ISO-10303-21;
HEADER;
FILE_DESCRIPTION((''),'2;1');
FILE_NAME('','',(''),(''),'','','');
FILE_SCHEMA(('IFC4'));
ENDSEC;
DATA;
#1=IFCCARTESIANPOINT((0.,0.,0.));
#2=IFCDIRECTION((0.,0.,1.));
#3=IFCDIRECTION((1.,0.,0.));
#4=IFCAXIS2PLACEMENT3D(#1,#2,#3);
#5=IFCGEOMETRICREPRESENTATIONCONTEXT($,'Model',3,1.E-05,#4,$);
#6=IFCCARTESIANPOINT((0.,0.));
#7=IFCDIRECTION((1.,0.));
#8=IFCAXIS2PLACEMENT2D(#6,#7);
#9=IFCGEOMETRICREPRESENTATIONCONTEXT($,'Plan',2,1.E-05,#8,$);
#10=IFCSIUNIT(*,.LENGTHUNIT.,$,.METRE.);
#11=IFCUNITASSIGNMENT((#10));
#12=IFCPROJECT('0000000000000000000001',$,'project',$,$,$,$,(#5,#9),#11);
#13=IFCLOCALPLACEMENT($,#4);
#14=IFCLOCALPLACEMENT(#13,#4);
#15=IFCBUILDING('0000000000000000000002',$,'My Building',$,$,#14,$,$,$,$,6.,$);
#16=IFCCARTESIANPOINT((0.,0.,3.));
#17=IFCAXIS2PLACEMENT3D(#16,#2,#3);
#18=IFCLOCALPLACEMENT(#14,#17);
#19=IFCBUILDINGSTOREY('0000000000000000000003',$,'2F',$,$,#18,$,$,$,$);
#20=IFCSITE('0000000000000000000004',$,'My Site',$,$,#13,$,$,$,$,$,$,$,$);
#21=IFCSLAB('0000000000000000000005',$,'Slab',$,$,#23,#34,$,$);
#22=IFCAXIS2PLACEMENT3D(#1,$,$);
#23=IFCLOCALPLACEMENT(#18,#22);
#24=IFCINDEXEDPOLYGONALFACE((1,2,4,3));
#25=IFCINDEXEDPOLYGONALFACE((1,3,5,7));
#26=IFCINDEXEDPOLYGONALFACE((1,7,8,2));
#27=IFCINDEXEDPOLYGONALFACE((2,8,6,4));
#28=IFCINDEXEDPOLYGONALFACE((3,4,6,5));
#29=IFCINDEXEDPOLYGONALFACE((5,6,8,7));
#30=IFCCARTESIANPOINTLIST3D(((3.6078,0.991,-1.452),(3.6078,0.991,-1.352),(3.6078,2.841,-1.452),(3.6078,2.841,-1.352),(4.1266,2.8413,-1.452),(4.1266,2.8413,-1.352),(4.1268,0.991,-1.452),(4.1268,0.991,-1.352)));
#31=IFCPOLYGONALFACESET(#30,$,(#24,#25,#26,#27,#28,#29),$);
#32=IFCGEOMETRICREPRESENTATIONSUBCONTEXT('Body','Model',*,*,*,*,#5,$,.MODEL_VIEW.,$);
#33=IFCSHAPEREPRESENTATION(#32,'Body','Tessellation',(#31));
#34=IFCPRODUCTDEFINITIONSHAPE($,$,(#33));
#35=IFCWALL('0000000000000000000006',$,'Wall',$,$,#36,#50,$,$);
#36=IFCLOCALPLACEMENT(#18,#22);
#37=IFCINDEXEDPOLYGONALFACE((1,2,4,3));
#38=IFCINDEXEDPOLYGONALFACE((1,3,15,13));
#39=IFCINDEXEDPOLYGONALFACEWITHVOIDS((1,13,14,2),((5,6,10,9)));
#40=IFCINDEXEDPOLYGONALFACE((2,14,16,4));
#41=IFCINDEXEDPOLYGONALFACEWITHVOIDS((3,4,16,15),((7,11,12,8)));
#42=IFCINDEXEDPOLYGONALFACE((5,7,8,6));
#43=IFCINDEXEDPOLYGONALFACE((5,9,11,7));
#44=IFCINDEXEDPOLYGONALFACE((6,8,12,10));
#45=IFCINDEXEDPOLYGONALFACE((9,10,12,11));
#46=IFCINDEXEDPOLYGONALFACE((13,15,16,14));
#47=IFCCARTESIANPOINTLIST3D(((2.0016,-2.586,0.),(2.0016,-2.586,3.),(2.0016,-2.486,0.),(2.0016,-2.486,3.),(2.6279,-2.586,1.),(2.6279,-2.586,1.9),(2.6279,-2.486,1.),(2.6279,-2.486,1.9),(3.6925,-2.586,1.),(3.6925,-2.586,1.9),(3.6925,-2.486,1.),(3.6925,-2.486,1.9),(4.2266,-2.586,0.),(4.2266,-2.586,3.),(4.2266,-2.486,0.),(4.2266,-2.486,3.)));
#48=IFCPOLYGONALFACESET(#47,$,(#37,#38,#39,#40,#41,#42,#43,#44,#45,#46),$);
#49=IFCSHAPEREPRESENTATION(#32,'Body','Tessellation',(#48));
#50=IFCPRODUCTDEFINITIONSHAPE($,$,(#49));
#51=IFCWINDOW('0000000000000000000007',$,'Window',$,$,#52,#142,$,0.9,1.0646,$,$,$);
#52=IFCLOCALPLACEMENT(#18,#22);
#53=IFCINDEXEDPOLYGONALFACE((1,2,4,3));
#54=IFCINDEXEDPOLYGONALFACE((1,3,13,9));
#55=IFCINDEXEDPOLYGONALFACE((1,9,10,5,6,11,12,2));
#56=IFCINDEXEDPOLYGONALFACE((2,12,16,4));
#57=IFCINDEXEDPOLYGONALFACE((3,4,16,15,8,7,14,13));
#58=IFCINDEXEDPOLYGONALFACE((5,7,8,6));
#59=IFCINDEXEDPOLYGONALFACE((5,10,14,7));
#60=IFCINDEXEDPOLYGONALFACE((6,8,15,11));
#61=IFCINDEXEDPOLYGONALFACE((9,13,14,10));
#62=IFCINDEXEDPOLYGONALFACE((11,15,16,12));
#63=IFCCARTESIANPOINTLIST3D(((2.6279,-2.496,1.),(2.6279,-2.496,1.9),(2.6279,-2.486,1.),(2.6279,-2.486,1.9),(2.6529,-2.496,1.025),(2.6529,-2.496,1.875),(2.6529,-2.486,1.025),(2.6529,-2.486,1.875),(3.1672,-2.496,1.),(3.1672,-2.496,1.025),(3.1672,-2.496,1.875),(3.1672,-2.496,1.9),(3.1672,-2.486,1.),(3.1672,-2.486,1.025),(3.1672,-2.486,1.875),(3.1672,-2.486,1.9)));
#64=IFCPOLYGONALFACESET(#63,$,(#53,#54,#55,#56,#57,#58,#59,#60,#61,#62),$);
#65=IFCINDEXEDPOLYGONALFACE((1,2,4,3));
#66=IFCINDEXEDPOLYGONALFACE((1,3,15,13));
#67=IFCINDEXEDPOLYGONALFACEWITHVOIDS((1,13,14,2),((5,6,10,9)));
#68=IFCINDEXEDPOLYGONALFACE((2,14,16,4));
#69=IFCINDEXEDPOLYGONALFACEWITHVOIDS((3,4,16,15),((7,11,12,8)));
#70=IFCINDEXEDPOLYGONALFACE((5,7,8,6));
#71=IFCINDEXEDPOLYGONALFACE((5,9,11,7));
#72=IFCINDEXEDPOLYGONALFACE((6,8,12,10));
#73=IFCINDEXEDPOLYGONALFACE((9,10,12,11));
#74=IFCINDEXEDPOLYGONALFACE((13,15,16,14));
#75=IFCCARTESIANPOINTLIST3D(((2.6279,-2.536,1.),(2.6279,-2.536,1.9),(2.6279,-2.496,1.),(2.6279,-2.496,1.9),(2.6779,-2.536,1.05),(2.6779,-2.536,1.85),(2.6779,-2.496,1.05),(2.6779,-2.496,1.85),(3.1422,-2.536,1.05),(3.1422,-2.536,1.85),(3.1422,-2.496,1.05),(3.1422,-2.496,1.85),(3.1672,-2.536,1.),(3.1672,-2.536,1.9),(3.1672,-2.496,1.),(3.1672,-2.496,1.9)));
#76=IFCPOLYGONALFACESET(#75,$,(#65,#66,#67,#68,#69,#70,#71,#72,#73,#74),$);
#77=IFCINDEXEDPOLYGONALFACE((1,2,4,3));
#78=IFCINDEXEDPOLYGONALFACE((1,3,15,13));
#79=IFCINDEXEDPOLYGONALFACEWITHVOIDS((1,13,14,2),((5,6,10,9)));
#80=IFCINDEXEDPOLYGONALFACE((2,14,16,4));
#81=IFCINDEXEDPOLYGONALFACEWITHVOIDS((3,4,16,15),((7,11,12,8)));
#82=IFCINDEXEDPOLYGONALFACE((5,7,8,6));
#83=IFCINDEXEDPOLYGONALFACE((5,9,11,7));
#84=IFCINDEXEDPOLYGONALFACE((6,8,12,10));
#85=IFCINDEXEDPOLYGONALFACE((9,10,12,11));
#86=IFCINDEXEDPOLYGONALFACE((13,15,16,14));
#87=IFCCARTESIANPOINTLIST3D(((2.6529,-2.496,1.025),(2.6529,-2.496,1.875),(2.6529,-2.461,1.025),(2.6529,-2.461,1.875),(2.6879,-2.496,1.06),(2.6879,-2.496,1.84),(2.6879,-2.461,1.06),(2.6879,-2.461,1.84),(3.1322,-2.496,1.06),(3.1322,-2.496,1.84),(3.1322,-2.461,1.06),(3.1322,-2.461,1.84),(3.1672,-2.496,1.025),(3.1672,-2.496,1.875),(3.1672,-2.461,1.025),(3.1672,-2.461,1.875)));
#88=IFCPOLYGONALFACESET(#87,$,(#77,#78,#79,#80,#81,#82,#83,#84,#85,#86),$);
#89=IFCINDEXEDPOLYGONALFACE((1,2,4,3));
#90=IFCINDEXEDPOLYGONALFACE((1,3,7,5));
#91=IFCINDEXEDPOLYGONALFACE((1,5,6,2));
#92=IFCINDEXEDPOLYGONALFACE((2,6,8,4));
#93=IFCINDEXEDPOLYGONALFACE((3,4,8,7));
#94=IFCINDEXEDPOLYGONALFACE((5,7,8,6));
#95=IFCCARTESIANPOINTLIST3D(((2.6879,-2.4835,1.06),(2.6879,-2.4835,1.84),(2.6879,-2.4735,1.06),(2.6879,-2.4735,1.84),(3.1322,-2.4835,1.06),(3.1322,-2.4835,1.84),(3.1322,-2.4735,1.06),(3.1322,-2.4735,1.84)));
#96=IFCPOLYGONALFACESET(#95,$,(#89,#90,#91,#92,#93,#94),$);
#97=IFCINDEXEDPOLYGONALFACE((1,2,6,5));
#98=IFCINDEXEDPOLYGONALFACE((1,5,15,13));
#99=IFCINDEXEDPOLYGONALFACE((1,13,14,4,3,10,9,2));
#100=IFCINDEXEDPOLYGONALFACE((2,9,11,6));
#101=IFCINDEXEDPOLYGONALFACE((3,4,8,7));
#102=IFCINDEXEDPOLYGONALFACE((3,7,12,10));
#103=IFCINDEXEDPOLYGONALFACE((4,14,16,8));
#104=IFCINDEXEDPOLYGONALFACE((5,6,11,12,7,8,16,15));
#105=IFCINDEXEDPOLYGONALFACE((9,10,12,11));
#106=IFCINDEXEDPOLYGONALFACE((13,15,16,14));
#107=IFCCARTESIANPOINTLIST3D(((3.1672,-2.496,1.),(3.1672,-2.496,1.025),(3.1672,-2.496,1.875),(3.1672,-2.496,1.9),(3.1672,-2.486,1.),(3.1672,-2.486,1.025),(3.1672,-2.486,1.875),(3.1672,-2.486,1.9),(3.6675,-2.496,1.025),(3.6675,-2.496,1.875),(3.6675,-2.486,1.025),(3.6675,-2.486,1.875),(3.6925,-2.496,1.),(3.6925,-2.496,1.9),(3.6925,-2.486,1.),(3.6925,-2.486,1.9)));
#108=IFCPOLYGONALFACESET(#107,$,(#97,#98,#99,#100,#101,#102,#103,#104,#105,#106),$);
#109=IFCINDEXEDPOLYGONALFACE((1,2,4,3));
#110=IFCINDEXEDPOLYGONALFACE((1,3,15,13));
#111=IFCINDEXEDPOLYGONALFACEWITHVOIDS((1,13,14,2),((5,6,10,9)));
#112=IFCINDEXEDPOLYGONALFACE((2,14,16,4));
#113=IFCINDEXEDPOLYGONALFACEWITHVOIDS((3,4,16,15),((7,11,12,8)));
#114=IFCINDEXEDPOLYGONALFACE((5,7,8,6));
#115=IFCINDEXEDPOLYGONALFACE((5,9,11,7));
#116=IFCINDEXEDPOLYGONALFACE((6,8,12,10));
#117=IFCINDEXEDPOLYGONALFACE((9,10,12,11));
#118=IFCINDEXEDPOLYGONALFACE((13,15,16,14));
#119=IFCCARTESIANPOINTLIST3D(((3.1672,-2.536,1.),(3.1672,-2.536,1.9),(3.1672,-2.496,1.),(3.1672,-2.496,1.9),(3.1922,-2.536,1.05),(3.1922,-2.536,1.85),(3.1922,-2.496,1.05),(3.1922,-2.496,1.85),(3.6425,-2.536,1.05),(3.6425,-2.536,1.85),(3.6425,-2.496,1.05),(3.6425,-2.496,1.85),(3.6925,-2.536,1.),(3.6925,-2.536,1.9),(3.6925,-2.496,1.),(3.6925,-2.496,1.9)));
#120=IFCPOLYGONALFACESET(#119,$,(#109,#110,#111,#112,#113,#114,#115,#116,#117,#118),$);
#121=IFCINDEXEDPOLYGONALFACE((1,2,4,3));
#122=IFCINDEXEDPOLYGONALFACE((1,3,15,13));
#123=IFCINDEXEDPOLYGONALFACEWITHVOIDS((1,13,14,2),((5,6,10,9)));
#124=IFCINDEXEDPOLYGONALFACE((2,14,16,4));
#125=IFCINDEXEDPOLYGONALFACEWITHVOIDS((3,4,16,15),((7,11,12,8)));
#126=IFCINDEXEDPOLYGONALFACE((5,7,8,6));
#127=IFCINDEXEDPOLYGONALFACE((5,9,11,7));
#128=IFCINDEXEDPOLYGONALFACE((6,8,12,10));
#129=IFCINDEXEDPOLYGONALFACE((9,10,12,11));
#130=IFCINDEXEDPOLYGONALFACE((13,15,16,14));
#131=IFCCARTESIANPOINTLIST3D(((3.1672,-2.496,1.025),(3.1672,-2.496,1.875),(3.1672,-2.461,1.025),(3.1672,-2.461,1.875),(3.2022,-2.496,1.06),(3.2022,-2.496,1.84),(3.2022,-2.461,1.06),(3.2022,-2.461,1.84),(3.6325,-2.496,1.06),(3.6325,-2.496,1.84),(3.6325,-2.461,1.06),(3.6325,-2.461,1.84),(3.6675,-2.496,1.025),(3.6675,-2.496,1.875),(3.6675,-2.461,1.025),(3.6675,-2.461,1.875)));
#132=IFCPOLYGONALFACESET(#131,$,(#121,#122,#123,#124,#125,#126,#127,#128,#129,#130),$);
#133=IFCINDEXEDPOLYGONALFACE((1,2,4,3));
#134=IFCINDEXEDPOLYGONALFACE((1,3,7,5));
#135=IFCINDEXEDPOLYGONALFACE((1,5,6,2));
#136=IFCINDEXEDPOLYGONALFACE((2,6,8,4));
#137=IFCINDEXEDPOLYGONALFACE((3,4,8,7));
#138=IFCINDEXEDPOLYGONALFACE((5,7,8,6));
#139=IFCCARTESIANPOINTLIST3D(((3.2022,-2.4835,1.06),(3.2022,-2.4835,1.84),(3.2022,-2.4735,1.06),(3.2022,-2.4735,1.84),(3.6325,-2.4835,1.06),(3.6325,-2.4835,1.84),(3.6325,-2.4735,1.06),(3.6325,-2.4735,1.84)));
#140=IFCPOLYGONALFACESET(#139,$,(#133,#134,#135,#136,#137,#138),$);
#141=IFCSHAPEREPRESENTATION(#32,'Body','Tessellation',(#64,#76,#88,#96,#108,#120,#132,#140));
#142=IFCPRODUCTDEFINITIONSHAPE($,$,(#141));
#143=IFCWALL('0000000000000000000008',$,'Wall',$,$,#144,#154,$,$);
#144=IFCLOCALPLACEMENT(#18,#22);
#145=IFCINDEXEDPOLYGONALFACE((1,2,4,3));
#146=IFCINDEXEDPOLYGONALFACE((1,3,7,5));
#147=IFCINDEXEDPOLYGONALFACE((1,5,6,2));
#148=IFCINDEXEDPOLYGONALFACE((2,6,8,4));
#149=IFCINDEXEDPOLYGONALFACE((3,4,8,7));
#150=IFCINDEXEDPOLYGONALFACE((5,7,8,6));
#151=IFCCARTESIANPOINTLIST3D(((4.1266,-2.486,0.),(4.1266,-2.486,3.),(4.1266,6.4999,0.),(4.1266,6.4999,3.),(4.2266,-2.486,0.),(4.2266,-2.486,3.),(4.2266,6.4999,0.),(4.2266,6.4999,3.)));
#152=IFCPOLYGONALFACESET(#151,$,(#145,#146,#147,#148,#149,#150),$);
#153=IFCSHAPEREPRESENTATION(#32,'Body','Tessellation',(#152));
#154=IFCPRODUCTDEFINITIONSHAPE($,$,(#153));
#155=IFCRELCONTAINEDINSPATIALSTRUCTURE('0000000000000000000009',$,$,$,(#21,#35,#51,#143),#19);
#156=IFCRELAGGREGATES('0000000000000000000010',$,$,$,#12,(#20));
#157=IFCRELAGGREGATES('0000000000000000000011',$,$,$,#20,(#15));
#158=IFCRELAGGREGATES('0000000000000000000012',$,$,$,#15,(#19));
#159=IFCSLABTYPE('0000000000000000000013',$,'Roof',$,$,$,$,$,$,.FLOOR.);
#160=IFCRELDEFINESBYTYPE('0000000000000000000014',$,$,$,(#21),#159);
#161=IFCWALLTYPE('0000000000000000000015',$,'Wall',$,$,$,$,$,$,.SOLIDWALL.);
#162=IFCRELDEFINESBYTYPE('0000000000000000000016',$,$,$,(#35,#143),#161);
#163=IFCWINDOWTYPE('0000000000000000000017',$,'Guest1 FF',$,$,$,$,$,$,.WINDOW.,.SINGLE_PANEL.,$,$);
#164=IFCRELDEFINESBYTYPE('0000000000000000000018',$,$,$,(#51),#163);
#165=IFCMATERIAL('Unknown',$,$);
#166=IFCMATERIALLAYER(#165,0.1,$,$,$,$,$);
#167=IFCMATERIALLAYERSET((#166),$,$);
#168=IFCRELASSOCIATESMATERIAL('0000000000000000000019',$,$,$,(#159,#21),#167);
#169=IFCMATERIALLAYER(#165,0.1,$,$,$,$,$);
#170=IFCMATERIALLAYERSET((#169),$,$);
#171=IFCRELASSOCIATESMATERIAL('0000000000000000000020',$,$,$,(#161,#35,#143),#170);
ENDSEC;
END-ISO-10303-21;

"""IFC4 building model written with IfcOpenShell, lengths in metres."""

from ifc_helpers import new_model, entity, si_unit, frame, origin_with_axes, origin_2d_with_axis, place, context, subcontext, project, spatial, line, indexed_curve, outline, extrude, shape, source, transform, mapped, material, layer, layer_set, layer_usage, type_object, type_shapes, element, fill, save


model = new_model("IFC4")

# Units and contexts
model_context = context("Model", 3, precision=1e-05, world=origin_with_axes())
plan_context = context("Plan", 2, precision=1e-05, world=origin_2d_with_axis())
body_context_1 = subcontext(model_context, "Body", "Model", "MODEL_VIEW")
body_context_2 = subcontext(plan_context, "Body", "Plan", "PLAN_VIEW")
ifc_project = project(units=[si_unit("LENGTHUNIT", "METRE")], contexts=[model_context, plan_context])

# Site, building, storey
site_placement = place(None, origin_with_axes())
site = spatial("IfcSite", under=ifc_project, at=site_placement, Name="My Site")
building_placement = place(site_placement, origin_with_axes())
building = spatial("IfcBuilding", under=site, at=building_placement, Name="My Building", ElevationOfTerrain=6.0)
storey_placement = place(building_placement, frame((0.0, 0.0, 3.0), z_axis=(0.0, 0.0, 1.0), x_axis=(1.0, 0.0, 0.0)))
storey = spatial("IfcBuildingStorey", under=building, at=storey_placement, Name="2F")

# Slab
ifc_material = material(Name="Unknown")
ifc_layer_1 = layer(ifc_material, 0.1)
ifc_layer_set_1 = layer_set([ifc_layer_1])
ifc_layer_usage_1 = layer_usage(ifc_layer_set_1, "AXIS3", "POSITIVE", -0.1)
slab_type = type_object("IfcSlabType", Name="Roof", PredefinedType="FLOOR", material=ifc_layer_set_1)
slab_placement = place(storey_placement, frame((4.1268, 0.991, -1.352), z_axis=(0.0, 0.0, 1.0), x_axis=(1.0, 0.0, 0.0)))
element("IfcSlab", 1, at=slab_placement, inside=storey, type_object=slab_type, material=ifc_layer_usage_1, Name="Slab", context=body_context_1, shape_type="SweptSolid", body=[
    extrude(outline(indexed_curve([(0.0, 0.0), (-0.519, 0.0), (-0.519, 1.85), (-0.0002, 1.8503), (0.0, 0.0)])), frame((0.0, 0.0, -0.1), z_axis=(0.0, 0.0, 1.0), x_axis=(1.0, 0.0, 0.0)), (0.0, 0.0, 1.0), 0.1),
])

# Wall, opening, window
ifc_layer_2 = layer(ifc_material, 0.1)
ifc_layer_set_2 = layer_set([ifc_layer_2])
ifc_layer_usage_2 = layer_usage(ifc_layer_set_2, "AXIS2", "POSITIVE", 0.0)
wall_type = type_object("IfcWallType", Name="Wall", PredefinedType="SOLIDWALL", material=ifc_layer_set_2)
wall_1_placement = place(storey_placement, frame((4.2266, -2.486, 0.0), z_axis=(0.0, 0.0, 1.0), x_axis=(-1.0, 0.0, 0.0)))
wall_1 = element("IfcWall", 2, at=wall_1_placement, inside=storey, type_object=wall_type, material=ifc_layer_usage_2, Name="Wall", context=body_context_1, shape_type="SweptSolid", body=[
    extrude(outline(indexed_curve([(0.0, 0.0), (0.0, 0.1), (2.225, 0.1), (2.225, 0.0)], segments=[line(1, 2, 3, 4, 1)])), origin_with_axes(), (0.0, 0.0, 1.0), 3.0),
])
shared_shape_1 = source(origin_with_axes(), body_context_1, "Body", "SweptSolid", [
    extrude(outline(indexed_curve([(0.0, 0.0), (1.0646, 0.0), (1.0646, 0.9), (0.0, 0.9)], segments=[line(1, 2, 3, 4, 1)])), frame((0.0, -0.6, 0.0), z_axis=(0.0, -1.0, 0.0), x_axis=(1.0, 0.0, 0.0)), (0.0, 0.0, -1.0), 1.2),
])
opening_1_placement = place(wall_1_placement, frame((1.5987, 0.1, 1.0), z_axis=(0.0, 0.0, 1.0), x_axis=(-1.0, 0.0, 0.0)))
opening_1 = element("IfcOpeningElement", 3, at=opening_1_placement, cuts=wall_1, PredefinedType="OPENING", context=body_context_1, shape_type="MappedRepresentation", body=[
    mapped(shared_shape_1, transform((0.0, 0.0, 0.0), x_axis=(1.0, 0.0, 0.0), y_axis=(0.0, 1.0, 0.0), z_axis=(0.0, 0.0, 1.0), scale=1.0)),
])
window_type_1 = type_object("IfcWindowType", Name="Guest1 FF", PartitioningType="SINGLE_PANEL", PredefinedType="WINDOW")
shared_shape_2 = source(origin_with_axes(), body_context_1, "Body", "SweptSolid", [
    extrude(outline(indexed_curve([(0.5393, 0.0), (0.0, 0.0), (0.0, 0.9), (0.5393, 0.9), (0.5393, 0.875), (0.025, 0.875), (0.025, 0.025), (0.5393, 0.025)], segments=[line(1, 2, 3, 4, 5, 6, 7, 8, 1)])), frame((0.0, 0.09, 0.0), z_axis=(0.0, -1.0, 0.0), x_axis=(1.0, 0.0, 0.0)), (0.0, 0.0, -1.0), 0.01),
    extrude(outline(indexed_curve([(0.0, 0.0), (0.5393, 0.0), (0.5393, 0.9), (0.0, 0.9)], segments=[line(1, 2, 3, 4, 1)]), holes=[indexed_curve([(0.05, 0.05), (0.5143, 0.05), (0.5143, 0.85), (0.05, 0.85)], segments=[line(1, 2, 3, 4, 1)])]), frame((0.0, 0.05, 0.0), z_axis=(0.0, -1.0, 0.0), x_axis=(1.0, 0.0, 0.0)), (0.0, 0.0, -1.0), 0.04),
    extrude(outline(indexed_curve([(0.0, 0.0), (0.5143, 0.0), (0.5143, 0.85), (0.0, 0.85)], segments=[line(1, 2, 3, 4, 1)]), holes=[indexed_curve([(0.035, 0.035), (0.4793, 0.035), (0.4793, 0.815), (0.035, 0.815)], segments=[line(1, 2, 3, 4, 1)])]), frame((0.025, 0.09, 0.025), z_axis=(0.0, -1.0, 0.0), x_axis=(1.0, 0.0, 0.0)), (0.0, 0.0, -1.0), 0.035),
    extrude(outline(indexed_curve([(0.035, 0.035), (0.4793, 0.035), (0.4793, 0.815), (0.035, 0.815)], segments=[line(1, 2, 3, 4, 1)])), frame((0.025, 0.1025, 0.025), z_axis=(0.0, -1.0, 0.0), x_axis=(1.0, 0.0, 0.0)), (0.0, 0.0, -1.0), 0.01),
    extrude(outline(indexed_curve([(0.0, 0.9), (0.5253, 0.9), (0.5253, 0.0), (0.0, 0.0), (0.0, 0.025), (0.5003, 0.025), (0.5003, 0.875), (0.0, 0.875)], segments=[line(1, 2, 3, 4, 5, 6, 7, 8, 1)])), frame((0.5393, 0.09, 0.0), z_axis=(0.0, -1.0, 0.0), x_axis=(1.0, 0.0, 0.0)), (0.0, 0.0, -1.0), 0.01),
    extrude(outline(indexed_curve([(0.0, 0.0), (0.5253, 0.0), (0.5253, 0.9), (0.0, 0.9)], segments=[line(1, 2, 3, 4, 1)]), holes=[indexed_curve([(0.025, 0.05), (0.4753, 0.05), (0.4753, 0.85), (0.025, 0.85)], segments=[line(1, 2, 3, 4, 1)])]), frame((0.5393, 0.05, 0.0), z_axis=(0.0, -1.0, 0.0), x_axis=(1.0, 0.0, 0.0)), (0.0, 0.0, -1.0), 0.04),
    extrude(outline(indexed_curve([(0.0, 0.0), (0.5003, 0.0), (0.5003, 0.85), (0.0, 0.85)], segments=[line(1, 2, 3, 4, 1)]), holes=[indexed_curve([(0.035, 0.035), (0.4653, 0.035), (0.4653, 0.815), (0.035, 0.815)], segments=[line(1, 2, 3, 4, 1)])]), frame((0.5393, 0.09, 0.025), z_axis=(0.0, -1.0, 0.0), x_axis=(1.0, 0.0, 0.0)), (0.0, 0.0, -1.0), 0.035),
    extrude(outline(indexed_curve([(0.035, 0.035), (0.4653, 0.035), (0.4653, 0.815), (0.035, 0.815)], segments=[line(1, 2, 3, 4, 1)])), frame((0.5393, 0.1025, 0.025), z_axis=(0.0, -1.0, 0.0), x_axis=(1.0, 0.0, 0.0)), (0.0, 0.0, -1.0), 0.01),
])
shared_shape_3 = source(origin_with_axes(), body_context_2, "Body", "Curve2D", [
    entity("IfcIndexedPolyCurve", entity("IfcCartesianPointList2D", [[0.05, 0.05], [0.5143, 0.05]])),
    entity("IfcIndexedPolyCurve", entity("IfcCartesianPointList2D", [[0.0, 0.1], [0.025, 0.1], [0.025, 0.09], [0.05, 0.09], [0.05, 0.05], [0.0, 0.05]]), [entity("IfcLineIndex", [1, 2, 3, 4, 5, 6, 1])]),
    entity("IfcIndexedPolyCurve", entity("IfcCartesianPointList2D", [[0.5393, 0.1], [0.5393, 0.1], [0.5393, 0.09], [0.5143, 0.09], [0.5143, 0.05], [0.5393, 0.05]])),
    entity("IfcIndexedPolyCurve", entity("IfcCartesianPointList2D", [[0.025, 0.09], [0.06, 0.09], [0.06, 0.125], [0.025, 0.125]]), [entity("IfcLineIndex", [1, 2, 3, 4, 1])]),
    entity("IfcIndexedPolyCurve", entity("IfcCartesianPointList2D", [[0.5393, 0.09], [0.5043, 0.09], [0.5043, 0.125], [0.5393, 0.125]]), [entity("IfcLineIndex", [1, 2, 3, 4, 1])]),
    entity("IfcIndexedPolyCurve", entity("IfcCartesianPointList2D", [[0.06, 0.09], [0.5043, 0.09]])),
    entity("IfcIndexedPolyCurve", entity("IfcCartesianPointList2D", [[0.06, 0.125], [0.5043, 0.125]])),
    entity("IfcIndexedPolyCurve", entity("IfcCartesianPointList2D", [[0.06, 0.1075], [0.5043, 0.1075]])),
    entity("IfcIndexedPolyCurve", entity("IfcCartesianPointList2D", [[0.5643, 0.05], [1.0146, 0.05]])),
    entity("IfcIndexedPolyCurve", entity("IfcCartesianPointList2D", [[0.5393, 0.1], [0.5393, 0.1], [0.5393, 0.09], [0.5643, 0.09], [0.5643, 0.05], [0.5393, 0.05]])),
    entity("IfcIndexedPolyCurve", entity("IfcCartesianPointList2D", [[1.0646, 0.1], [1.0396, 0.1], [1.0396, 0.09], [1.0146, 0.09], [1.0146, 0.05], [1.0646, 0.05]]), [entity("IfcLineIndex", [1, 2, 3, 4, 5, 6, 1])]),
    entity("IfcIndexedPolyCurve", entity("IfcCartesianPointList2D", [[0.5393, 0.09], [0.5743, 0.09], [0.5743, 0.125], [0.5393, 0.125]]), [entity("IfcLineIndex", [1, 2, 3, 4, 1])]),
    entity("IfcIndexedPolyCurve", entity("IfcCartesianPointList2D", [[1.0396, 0.09], [1.0046, 0.09], [1.0046, 0.125], [1.0396, 0.125]]), [entity("IfcLineIndex", [1, 2, 3, 4, 1])]),
    entity("IfcIndexedPolyCurve", entity("IfcCartesianPointList2D", [[0.5743, 0.09], [1.0046, 0.09]])),
    entity("IfcIndexedPolyCurve", entity("IfcCartesianPointList2D", [[0.5743, 0.125], [1.0046, 0.125]])),
    entity("IfcIndexedPolyCurve", entity("IfcCartesianPointList2D", [[0.5743, 0.1075], [1.0046, 0.1075]])),
])
type_shapes(window_type_1, [shared_shape_2, shared_shape_3])
window_1_placement = place(opening_1_placement, frame((0.0, 0.0, 0.0), z_axis=(0.0, 0.0, 1.0), x_axis=(1.0, 0.0, 0.0)))
window_1 = element("IfcWindow", 4, at=window_1_placement, inside=storey, type_object=window_type_1, Name="Window", OverallHeight=0.9, OverallWidth=1.0646, shapes=[
    shape(body_context_1, "Body", "MappedRepresentation", [mapped(shared_shape_2, transform((0.0, 0.0, 0.0), x_axis=(1.0, 0.0, 0.0), y_axis=(0.0, 1.0, 0.0), z_axis=(0.0, 0.0, 1.0), scale=1.0))]),
    shape(body_context_2, "Body", "MappedRepresentation", [mapped(shared_shape_3, transform((0.0, 0.0, 0.0), x_axis=(1.0, 0.0, 0.0), y_axis=(0.0, 1.0, 0.0), z_axis=(0.0, 0.0, 1.0), scale=1.0))]),
])
fill(opening_1, window_1)

# Wall
ifc_layer_usage_3 = layer_usage(ifc_layer_set_2, "AXIS2", "POSITIVE", 0.0)
wall_2_placement = place(storey_placement, frame((4.2266, -2.486, 0.0), z_axis=(0.0, 0.0, 1.0), x_axis=(0.0, 1.0, 0.0)))
element("IfcWall", 5, at=wall_2_placement, inside=storey, type_object=wall_type, material=ifc_layer_usage_3, Name="Wall", context=body_context_1, shape_type="SweptSolid", body=[
    extrude(outline(indexed_curve([(0.0, 0.0), (0.0, 0.1), (8.9859, 0.1), (8.9859, 0.0)], segments=[line(1, 2, 3, 4, 1)])), origin_with_axes(), (0.0, 0.0, 1.0), 3.0),
])

save(model, "model.ifc")
